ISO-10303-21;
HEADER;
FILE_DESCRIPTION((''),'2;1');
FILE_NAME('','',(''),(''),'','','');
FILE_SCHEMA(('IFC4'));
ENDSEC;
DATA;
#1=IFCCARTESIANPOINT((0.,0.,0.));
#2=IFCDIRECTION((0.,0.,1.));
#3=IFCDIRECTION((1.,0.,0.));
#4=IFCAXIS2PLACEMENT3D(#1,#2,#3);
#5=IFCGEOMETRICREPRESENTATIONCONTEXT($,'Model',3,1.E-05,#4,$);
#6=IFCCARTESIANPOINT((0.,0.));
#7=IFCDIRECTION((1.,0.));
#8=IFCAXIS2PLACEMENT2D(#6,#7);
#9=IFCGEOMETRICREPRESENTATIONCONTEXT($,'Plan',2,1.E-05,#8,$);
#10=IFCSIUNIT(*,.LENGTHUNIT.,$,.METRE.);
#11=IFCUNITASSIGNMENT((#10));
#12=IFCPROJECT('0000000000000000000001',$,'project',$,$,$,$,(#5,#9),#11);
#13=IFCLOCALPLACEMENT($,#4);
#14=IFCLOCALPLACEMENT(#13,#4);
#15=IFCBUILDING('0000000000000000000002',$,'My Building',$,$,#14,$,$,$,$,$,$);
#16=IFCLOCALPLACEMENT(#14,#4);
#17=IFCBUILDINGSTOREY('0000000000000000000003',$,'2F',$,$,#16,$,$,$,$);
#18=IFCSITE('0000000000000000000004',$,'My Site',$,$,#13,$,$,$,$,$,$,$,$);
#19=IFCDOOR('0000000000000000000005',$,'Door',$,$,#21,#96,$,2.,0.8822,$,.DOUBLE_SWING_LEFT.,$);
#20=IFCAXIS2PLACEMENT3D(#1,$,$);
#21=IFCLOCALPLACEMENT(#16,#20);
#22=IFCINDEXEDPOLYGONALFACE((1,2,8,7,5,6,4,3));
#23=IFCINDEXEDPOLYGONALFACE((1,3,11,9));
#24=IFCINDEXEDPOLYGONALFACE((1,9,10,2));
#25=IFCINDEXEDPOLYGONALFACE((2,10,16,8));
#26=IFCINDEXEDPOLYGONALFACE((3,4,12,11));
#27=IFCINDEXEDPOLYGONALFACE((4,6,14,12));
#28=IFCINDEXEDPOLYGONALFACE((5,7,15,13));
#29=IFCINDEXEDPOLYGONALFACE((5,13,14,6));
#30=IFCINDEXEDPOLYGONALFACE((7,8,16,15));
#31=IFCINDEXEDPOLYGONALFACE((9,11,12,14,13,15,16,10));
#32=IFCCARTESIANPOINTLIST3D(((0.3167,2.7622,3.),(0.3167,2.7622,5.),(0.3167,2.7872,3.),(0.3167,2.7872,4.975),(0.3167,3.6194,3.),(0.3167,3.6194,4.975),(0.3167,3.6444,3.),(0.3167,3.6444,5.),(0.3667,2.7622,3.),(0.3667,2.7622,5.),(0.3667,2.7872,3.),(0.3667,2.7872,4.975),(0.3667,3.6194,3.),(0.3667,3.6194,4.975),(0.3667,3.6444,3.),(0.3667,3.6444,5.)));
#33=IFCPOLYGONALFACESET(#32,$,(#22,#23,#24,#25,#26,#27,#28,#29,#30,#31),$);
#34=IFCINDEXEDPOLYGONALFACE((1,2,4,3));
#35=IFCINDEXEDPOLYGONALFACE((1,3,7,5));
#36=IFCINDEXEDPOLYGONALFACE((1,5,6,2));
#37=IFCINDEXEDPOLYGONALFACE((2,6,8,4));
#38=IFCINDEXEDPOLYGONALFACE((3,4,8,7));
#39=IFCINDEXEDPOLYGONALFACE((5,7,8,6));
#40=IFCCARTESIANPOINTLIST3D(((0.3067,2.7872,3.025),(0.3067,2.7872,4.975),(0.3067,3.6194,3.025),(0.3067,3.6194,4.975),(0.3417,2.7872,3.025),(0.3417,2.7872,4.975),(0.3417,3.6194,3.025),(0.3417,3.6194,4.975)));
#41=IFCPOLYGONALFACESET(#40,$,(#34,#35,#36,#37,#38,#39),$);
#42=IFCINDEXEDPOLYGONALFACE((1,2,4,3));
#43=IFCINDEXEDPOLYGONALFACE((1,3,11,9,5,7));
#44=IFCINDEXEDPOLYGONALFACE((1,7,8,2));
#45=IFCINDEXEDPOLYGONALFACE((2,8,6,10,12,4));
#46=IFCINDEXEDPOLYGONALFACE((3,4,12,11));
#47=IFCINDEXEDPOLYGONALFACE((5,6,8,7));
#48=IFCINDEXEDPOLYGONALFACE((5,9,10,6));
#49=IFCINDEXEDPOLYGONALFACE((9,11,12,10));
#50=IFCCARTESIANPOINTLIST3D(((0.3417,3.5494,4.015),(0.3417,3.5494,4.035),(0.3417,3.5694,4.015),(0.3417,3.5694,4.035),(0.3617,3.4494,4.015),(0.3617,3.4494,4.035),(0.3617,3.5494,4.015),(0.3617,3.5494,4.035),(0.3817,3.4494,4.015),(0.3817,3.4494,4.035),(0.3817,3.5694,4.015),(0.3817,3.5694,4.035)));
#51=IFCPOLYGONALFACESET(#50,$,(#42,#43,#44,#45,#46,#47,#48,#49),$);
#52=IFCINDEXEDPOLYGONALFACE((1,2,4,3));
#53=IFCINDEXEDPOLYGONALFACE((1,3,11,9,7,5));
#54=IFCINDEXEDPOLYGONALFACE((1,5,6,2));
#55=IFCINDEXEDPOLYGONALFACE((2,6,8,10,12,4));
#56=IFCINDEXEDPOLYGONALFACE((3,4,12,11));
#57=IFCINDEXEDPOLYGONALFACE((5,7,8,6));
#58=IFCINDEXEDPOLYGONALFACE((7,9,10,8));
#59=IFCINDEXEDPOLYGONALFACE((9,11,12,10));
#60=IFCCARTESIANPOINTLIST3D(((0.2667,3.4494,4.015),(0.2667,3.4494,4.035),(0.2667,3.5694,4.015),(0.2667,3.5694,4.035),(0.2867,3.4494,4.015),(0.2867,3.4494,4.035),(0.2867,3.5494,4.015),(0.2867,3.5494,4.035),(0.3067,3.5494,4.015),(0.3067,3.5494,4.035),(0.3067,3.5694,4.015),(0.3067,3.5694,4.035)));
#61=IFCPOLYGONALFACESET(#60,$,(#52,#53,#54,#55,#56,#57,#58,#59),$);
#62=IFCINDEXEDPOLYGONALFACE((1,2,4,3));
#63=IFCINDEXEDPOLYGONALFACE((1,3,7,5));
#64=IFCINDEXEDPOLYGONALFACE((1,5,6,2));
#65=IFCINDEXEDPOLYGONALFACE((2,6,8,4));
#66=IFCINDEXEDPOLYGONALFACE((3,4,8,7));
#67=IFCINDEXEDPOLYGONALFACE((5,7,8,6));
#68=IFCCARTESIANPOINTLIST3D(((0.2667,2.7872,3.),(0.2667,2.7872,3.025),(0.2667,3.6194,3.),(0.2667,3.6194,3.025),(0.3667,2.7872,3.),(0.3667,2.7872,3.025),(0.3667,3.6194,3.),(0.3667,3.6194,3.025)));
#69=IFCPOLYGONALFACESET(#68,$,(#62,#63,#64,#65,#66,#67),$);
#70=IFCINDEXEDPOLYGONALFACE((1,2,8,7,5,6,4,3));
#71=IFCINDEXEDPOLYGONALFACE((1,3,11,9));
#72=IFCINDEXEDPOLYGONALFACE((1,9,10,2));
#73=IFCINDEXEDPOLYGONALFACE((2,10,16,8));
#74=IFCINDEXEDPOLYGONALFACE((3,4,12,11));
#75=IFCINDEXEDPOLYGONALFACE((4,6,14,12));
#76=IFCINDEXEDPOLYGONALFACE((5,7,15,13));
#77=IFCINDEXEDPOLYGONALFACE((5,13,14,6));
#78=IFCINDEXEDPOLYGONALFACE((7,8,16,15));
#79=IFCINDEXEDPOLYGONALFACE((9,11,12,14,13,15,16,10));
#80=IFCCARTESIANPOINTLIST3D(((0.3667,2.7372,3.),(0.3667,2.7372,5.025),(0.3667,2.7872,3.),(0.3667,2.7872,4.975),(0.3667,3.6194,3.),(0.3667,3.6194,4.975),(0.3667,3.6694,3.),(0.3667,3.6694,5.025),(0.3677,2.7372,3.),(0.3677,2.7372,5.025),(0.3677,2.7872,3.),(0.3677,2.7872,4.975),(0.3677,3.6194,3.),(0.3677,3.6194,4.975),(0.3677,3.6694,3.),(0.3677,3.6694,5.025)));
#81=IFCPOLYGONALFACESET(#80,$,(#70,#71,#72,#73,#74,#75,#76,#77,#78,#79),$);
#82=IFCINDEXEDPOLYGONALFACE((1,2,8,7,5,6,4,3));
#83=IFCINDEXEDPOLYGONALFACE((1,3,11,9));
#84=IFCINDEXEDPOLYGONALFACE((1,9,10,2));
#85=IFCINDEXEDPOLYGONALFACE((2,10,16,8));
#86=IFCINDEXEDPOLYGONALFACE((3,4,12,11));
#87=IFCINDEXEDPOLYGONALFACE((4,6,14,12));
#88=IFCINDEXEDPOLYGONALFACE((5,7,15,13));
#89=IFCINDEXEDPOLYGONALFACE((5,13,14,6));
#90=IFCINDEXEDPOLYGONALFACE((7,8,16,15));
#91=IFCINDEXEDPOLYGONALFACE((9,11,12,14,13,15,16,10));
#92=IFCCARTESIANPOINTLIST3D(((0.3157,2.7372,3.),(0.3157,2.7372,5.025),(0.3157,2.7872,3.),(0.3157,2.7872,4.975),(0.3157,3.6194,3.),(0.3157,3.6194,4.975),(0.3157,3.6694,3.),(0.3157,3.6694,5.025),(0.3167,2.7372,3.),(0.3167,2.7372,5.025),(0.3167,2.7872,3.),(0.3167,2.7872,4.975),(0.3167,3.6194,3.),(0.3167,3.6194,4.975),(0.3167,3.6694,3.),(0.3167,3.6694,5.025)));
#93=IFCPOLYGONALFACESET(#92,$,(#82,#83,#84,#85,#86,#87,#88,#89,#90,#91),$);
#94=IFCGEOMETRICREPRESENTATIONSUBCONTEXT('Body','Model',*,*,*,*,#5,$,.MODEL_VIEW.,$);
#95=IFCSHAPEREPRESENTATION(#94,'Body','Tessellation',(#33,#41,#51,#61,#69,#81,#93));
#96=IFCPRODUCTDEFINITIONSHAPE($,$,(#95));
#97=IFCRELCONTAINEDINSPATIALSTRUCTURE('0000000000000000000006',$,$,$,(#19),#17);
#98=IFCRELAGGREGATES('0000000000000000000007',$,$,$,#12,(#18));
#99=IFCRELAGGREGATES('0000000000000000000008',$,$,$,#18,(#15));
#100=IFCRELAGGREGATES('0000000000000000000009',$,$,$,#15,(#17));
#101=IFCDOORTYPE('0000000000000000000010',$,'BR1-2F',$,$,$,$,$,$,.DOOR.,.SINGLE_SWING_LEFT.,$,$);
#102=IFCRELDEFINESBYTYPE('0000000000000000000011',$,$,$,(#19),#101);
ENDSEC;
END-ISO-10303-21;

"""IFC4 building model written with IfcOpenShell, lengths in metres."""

from ifc_helpers import new_model, entity, si_unit, frame, origin_with_axes, origin_2d_with_axis, place, context, subcontext, project, spatial, line, indexed_curve, outline, extrude, shape, source, transform, mapped, type_object, type_shapes, element, save


model = new_model("IFC4")

# Units and contexts
model_context = context("Model", 3, precision=1e-05, world=origin_with_axes())
plan_context = context("Plan", 2, precision=1e-05, world=origin_2d_with_axis())
body_context_1 = subcontext(model_context, "Body", "Model", "MODEL_VIEW")
body_context_2 = subcontext(plan_context, "Body", "Plan", "PLAN_VIEW")
ifc_project = project(units=[si_unit("LENGTHUNIT", "METRE")], contexts=[model_context, plan_context])

# Site, building, storey
site_placement = place(None, origin_with_axes())
site = spatial("IfcSite", under=ifc_project, at=site_placement, Name="My Site")
building_placement = place(site_placement, origin_with_axes())
building = spatial("IfcBuilding", under=site, at=building_placement, Name="My Building")
storey_placement = place(building_placement, origin_with_axes())
storey = spatial("IfcBuildingStorey", under=building, at=storey_placement, Name="2F")

# Door
door_type_1 = type_object("IfcDoorType", Name="BR1-2F", OperationType="SINGLE_SWING_LEFT", PredefinedType="DOOR")
shared_shape_1 = source(origin_with_axes(), body_context_1, "Body", "SweptSolid", [
    extrude(outline(indexed_curve([(0.0, 0.0), (0.0, 2.0), (0.8822, 2.0), (0.8822, 0.0), (0.8572, 0.0), (0.8572, 1.975), (0.025, 1.975), (0.025, 0.0)], segments=[line(1, 2, 3, 4, 5, 6, 7, 8, 1)])), frame((0.0, 0.0, 0.0), z_axis=(0.0, -1.0, 0.0), x_axis=(1.0, 0.0, 0.0)), (0.0, 0.0, -1.0), 0.05),
    extrude(outline(indexed_curve([(0.0, 0.0), (0.8322, 0.0), (0.8322, 0.035), (0.0, 0.035)], segments=[line(1, 2, 3, 4, 1)])), frame((0.025, 0.025, 0.025), z_axis=(0.0, 0.0, 1.0), x_axis=(1.0, 0.0, 0.0)), (0.0, 0.0, 1.0), 1.95),
    extrude(outline(indexed_curve([(0.0, 0.0), (0.0, -0.04), (-0.12, -0.04), (-0.12, -0.02), (-0.02, -0.02), (-0.02, 0.0)], segments=[line(1, 2, 3, 4, 5, 6, 1)])), frame((0.8072, 0.025, 1.015), z_axis=(0.0, 0.0, 1.0), x_axis=(1.0, 0.0, 0.0)), (0.0, 0.0, 1.0), 0.02),
    extrude(outline(indexed_curve([(0.0, 0.0), (0.0, 0.04), (-0.12, 0.04), (-0.12, 0.02), (-0.02, 0.02), (-0.02, 0.0)], segments=[line(1, 2, 3, 4, 5, 6, 1)])), frame((0.8072, 0.06, 1.015), z_axis=(0.0, 0.0, 1.0), x_axis=(1.0, 0.0, 0.0)), (0.0, 0.0, 1.0), 0.02),
    extrude(outline(indexed_curve([(0.0, 0.0), (0.8322, 0.0), (0.8322, 0.1), (0.0, 0.1)], segments=[line(1, 2, 3, 4, 1)])), frame((0.025, 0.0, 0.0), z_axis=(0.0, 0.0, 1.0), x_axis=(1.0, 0.0, 0.0)), (0.0, 0.0, 1.0), 0.025),
    extrude(outline(indexed_curve([(0.0, 0.0), (0.0, 2.025), (0.9322, 2.025), (0.9322, 0.0), (0.8822, 0.0), (0.8822, 1.975), (0.05, 1.975), (0.05, 0.0)], segments=[line(1, 2, 3, 4, 5, 6, 7, 8, 1)])), frame((-0.025, -0.001, 0.0), z_axis=(0.0, -1.0, 0.0), x_axis=(1.0, 0.0, 0.0)), (0.0, 0.0, -1.0), 0.001),
    extrude(outline(indexed_curve([(0.0, 0.0), (0.0, 2.025), (0.9322, 2.025), (0.9322, 0.0), (0.8822, 0.0), (0.8822, 1.975), (0.05, 1.975), (0.05, 0.0)], segments=[line(1, 2, 3, 4, 5, 6, 7, 8, 1)])), frame((-0.025, 0.05, 0.0), z_axis=(0.0, -1.0, 0.0), x_axis=(1.0, 0.0, 0.0)), (0.0, 0.0, -1.0), 0.001),
])
shared_shape_2 = source(origin_with_axes(), body_context_2, "Body", "Curve2D", [
    entity("IfcIndexedPolyCurve", entity("IfcCartesianPointList2D", [[0.0, 0.0], [0.025, 0.0], [0.025, 0.05], [0.0, 0.05]]), [entity("IfcLineIndex", [1, 2, 3, 4, 1])]),
    entity("IfcIndexedPolyCurve", entity("IfcCartesianPointList2D", [[0.8822, 0.0], [0.8572, 0.0], [0.8572, 0.05], [0.8822, 0.05]]), [entity("IfcLineIndex", [1, 2, 3, 4, 1])]),
    entity("IfcIndexedPolyCurve", entity("IfcCartesianPointList2D", [[0.025, 0.05], [0.025, -0.7822], [0.06, -0.7822]])),
    entity("IfcTrimmedCurve", entity("IfcEllipse", entity("IfcAxis2Placement2D", entity("IfcCartesianPoint", [0.06, 0.05]), entity("IfcDirection", [1.0, 0.0])), 0.7972, 0.8322), [entity("IfcCartesianPoint", [0.06, -0.7822])], [entity("IfcCartesianPoint", [0.06, 0.8822])], True, "CARTESIAN"),
    entity("IfcIndexedPolyCurve", entity("IfcCartesianPointList2D", [[0.025, 0.05], [0.06, 0.05], [0.06, 0.8822], [0.025, 0.8822]]), [entity("IfcLineIndex", [1, 2, 3, 4, 1])]),
])
type_shapes(door_type_1, [shared_shape_1, shared_shape_2])
placement_1 = place(storey_placement, frame((0.2817, 6.52, 3.0), z_axis=(0.0, 0.0, 1.0), x_axis=(0.0, -1.0, 0.0)))
placement_2 = place(placement_1, frame((3.7578, 0.085, 0.0), z_axis=(0.0, 0.0, 1.0), x_axis=(-1.0, 0.0, 0.0)))
door_1_placement = place(placement_2, frame((0.0, 0.0, 0.0), z_axis=(0.0, 0.0, 1.0), x_axis=(1.0, 0.0, 0.0)))
element("IfcDoor", 1, at=door_1_placement, inside=storey, type_object=door_type_1, Name="Door", OperationType="DOUBLE_SWING_LEFT", OverallHeight=2.0, OverallWidth=0.8822, shapes=[
    shape(body_context_1, "Body", "MappedRepresentation", [mapped(shared_shape_1, transform((0.0, 0.0, 0.0), x_axis=(1.0, 0.0, 0.0), y_axis=(0.0, 1.0, 0.0), z_axis=(0.0, 0.0, 1.0), scale=1.0))]),
    shape(body_context_2, "Body", "MappedRepresentation", [mapped(shared_shape_2, transform((0.0, 0.0, 0.0), x_axis=(1.0, 0.0, 0.0), y_axis=(0.0, 1.0, 0.0), z_axis=(0.0, 0.0, 1.0), scale=1.0))]),
])

save(model, "model.ifc")
